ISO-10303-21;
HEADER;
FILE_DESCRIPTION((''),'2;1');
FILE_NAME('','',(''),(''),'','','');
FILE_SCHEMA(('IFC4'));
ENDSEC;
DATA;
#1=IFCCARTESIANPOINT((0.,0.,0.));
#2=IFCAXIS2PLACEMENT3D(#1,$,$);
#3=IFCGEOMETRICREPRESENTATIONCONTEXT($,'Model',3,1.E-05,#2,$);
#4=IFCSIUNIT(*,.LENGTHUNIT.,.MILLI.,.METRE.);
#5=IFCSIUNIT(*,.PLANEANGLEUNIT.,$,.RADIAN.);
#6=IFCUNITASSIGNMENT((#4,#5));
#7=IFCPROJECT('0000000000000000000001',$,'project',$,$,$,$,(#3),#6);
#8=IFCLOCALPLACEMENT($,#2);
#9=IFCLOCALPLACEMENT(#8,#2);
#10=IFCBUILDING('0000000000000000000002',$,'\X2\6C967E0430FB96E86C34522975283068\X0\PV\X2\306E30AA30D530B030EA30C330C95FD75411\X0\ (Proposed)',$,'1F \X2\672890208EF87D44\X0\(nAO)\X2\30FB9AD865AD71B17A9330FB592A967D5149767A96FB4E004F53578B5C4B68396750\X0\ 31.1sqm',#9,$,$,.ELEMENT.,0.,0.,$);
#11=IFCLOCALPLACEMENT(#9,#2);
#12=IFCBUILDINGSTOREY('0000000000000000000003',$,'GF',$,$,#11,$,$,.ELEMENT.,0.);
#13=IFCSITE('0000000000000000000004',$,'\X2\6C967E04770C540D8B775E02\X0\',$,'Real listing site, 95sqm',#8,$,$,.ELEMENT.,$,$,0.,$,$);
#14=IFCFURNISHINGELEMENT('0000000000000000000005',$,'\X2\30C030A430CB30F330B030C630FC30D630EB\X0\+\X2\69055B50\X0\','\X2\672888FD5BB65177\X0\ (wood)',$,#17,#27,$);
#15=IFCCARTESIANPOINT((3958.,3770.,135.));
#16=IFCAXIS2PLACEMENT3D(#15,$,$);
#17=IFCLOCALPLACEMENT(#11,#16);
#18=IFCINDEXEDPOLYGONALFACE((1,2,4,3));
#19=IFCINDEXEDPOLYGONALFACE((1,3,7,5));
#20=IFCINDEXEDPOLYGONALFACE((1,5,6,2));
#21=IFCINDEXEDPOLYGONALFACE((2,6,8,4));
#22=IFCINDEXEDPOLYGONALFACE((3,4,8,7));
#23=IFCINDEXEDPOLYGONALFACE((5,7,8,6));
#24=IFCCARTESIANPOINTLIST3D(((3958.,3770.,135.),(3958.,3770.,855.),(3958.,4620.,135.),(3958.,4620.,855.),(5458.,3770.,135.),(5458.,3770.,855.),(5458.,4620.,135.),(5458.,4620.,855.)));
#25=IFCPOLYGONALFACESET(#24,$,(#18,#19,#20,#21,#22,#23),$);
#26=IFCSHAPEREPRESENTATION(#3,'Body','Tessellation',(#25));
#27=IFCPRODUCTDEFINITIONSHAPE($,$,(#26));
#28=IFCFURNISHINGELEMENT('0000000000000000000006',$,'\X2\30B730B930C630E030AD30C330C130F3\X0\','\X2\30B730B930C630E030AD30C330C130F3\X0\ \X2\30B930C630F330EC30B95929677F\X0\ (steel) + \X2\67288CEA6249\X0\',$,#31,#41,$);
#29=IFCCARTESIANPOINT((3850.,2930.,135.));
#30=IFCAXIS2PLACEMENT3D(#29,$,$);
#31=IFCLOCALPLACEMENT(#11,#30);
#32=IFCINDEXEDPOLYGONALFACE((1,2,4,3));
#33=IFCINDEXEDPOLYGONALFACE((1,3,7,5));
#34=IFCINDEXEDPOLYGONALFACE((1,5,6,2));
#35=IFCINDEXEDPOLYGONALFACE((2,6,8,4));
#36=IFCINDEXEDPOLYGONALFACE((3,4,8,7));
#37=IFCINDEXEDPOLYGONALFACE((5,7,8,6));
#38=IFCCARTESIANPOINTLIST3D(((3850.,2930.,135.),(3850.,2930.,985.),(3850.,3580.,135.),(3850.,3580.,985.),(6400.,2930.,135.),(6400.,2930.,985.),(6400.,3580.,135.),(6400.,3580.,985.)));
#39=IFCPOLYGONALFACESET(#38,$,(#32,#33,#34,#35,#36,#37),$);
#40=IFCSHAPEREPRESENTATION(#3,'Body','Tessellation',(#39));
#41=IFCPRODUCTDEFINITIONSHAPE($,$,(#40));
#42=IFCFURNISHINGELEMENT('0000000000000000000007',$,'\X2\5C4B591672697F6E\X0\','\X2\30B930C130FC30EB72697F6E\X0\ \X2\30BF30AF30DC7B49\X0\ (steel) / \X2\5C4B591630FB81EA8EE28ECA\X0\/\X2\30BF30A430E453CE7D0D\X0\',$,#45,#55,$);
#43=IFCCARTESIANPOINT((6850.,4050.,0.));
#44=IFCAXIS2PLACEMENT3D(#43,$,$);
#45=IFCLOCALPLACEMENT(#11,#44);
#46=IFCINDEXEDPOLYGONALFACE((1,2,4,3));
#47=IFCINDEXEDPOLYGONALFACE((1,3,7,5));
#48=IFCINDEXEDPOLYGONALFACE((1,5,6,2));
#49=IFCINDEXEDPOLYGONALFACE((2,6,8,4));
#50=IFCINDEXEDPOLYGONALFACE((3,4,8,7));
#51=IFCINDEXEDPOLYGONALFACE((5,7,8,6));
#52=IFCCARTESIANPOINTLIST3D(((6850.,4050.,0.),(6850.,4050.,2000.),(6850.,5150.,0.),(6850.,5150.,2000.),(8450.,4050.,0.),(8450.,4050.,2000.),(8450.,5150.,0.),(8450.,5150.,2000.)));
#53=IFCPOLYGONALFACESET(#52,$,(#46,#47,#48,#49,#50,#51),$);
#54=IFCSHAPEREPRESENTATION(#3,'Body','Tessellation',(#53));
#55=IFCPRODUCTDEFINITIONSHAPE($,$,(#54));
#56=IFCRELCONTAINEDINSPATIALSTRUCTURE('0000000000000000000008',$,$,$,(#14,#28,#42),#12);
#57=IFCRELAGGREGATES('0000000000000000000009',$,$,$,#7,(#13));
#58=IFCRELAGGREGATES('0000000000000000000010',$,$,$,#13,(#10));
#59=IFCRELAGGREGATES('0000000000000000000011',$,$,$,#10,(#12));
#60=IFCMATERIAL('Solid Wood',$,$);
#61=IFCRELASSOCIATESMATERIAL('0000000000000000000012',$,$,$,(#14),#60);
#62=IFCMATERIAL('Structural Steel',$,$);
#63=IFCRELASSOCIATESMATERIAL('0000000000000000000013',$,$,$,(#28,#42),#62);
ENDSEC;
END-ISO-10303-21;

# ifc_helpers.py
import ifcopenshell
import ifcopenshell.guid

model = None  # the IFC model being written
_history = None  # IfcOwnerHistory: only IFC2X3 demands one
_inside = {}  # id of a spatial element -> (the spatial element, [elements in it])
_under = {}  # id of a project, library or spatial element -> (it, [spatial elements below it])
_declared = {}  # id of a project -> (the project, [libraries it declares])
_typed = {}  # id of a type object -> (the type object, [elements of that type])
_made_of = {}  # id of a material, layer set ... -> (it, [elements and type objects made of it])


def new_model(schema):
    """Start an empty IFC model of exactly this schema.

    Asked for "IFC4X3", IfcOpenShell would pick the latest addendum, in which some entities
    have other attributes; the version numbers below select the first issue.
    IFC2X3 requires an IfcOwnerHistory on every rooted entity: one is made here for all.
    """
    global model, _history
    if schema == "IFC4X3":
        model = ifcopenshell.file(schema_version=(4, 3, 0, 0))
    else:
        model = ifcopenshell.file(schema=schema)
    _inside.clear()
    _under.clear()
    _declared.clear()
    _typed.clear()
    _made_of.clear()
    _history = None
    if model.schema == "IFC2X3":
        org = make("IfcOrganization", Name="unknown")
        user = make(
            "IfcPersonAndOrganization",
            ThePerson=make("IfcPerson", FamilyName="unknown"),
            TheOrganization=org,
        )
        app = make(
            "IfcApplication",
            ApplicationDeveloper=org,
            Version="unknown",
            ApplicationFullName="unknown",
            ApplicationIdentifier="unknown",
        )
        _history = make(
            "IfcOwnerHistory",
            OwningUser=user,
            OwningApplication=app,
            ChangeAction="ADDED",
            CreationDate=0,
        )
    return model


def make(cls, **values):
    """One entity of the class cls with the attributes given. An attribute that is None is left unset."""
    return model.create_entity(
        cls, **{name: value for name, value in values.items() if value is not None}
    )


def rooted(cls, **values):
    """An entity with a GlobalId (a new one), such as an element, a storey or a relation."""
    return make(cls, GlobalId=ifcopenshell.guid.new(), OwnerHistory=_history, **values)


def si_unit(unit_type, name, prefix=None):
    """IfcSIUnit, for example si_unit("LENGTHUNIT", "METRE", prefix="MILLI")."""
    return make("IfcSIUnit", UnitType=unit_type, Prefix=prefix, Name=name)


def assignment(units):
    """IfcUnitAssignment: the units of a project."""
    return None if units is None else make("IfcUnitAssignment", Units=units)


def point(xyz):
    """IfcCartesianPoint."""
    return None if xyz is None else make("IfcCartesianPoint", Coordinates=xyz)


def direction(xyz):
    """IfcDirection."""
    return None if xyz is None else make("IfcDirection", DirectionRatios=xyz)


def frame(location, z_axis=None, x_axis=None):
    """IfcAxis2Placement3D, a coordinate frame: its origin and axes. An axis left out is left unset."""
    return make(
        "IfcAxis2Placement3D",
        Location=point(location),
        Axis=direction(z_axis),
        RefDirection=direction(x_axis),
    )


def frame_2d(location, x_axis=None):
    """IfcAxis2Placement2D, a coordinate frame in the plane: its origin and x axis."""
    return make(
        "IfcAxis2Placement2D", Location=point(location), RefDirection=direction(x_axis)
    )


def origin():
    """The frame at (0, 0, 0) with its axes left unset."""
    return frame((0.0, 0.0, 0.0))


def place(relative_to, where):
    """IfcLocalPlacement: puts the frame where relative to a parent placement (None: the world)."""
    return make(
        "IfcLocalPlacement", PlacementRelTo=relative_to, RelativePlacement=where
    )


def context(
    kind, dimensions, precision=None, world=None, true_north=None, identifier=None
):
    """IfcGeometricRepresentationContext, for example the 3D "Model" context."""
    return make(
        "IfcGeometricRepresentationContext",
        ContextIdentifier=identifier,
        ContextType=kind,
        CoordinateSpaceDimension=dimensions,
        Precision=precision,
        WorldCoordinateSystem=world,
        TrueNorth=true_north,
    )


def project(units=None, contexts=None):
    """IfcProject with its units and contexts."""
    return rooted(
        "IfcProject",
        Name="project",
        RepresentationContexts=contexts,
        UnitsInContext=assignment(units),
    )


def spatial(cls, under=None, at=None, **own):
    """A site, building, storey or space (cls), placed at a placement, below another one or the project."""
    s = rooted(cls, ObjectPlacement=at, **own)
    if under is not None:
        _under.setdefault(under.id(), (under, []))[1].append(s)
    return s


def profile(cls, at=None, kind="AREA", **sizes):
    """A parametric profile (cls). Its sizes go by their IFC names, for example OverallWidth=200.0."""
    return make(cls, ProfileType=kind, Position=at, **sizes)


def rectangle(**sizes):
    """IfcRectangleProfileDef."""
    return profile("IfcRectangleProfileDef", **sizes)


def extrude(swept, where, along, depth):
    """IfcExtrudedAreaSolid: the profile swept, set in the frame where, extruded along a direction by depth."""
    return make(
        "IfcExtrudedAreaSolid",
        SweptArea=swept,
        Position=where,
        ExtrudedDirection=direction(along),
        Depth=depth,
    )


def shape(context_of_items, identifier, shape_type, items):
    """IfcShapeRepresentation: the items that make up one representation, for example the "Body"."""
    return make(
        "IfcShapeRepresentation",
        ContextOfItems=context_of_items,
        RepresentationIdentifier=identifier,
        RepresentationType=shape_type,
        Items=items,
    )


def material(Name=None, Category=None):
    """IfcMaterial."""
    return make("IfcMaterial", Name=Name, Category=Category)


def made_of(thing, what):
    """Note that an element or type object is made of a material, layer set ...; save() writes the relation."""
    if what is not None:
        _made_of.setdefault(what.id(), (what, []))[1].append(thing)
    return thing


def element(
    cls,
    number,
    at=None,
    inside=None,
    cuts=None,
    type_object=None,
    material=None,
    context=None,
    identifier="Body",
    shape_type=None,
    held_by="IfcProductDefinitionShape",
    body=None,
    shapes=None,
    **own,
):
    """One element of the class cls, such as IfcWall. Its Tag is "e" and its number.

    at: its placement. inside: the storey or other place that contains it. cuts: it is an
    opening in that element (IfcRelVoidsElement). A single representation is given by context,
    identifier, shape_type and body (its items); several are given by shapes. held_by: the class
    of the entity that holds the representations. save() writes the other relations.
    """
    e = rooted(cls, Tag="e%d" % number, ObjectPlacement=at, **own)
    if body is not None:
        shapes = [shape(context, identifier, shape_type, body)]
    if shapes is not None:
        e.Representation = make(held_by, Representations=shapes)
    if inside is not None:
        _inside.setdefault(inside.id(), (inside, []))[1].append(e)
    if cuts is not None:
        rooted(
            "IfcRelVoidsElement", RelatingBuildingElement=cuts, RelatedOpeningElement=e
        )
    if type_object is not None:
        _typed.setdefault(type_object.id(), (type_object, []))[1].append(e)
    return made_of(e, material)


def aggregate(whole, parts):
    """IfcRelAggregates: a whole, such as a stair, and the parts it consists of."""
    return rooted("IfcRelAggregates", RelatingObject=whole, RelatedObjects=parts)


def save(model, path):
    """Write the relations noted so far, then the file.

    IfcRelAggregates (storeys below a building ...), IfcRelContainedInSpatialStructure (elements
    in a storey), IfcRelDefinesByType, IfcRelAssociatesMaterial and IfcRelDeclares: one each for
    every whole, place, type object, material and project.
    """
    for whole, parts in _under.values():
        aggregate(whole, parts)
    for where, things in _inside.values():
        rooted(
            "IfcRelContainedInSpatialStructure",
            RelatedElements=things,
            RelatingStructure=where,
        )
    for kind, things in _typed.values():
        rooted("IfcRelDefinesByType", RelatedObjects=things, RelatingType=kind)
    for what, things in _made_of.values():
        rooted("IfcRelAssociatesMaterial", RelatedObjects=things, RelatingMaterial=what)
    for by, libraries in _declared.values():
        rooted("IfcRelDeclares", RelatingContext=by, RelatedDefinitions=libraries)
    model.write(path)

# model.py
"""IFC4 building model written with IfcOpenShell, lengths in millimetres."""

from ifc_helpers import new_model, si_unit, frame, frame_2d, origin, place, context, project, spatial, rectangle, extrude, material, element, save


model = new_model("IFC4")

# Units and contexts
model_context = context("Model", 3, precision=1e-05, world=origin())
ifc_project = project(units=[si_unit("LENGTHUNIT", "METRE", prefix="MILLI"), si_unit("PLANEANGLEUNIT", "RADIAN")], contexts=[model_context])

# Site, building, storey
site_placement = place(None, origin())
site = spatial("IfcSite", under=ifc_project, at=site_placement, Name="沖縄県名護市", ObjectType="Real listing site, 95sqm", CompositionType="ELEMENT", RefElevation=0.0)
building_placement = place(site_placement, origin())
building = spatial("IfcBuilding", under=site, at=building_placement, Name="沖縄・雨水利用とPVのオフグリッド志向 (Proposed)", ObjectType="1F 木造軸組(nAO)・高断熱窓・太陽光発電一体型屋根材 31.1sqm", CompositionType="ELEMENT", ElevationOfRefHeight=0.0, ElevationOfTerrain=0.0)
storey_placement = place(building_placement, origin())
storey = spatial("IfcBuildingStorey", under=building, at=storey_placement, Name="GF", CompositionType="ELEMENT", Elevation=0.0)

# Shared definitions
ifc_material_1 = material(Name="Solid Wood")

# Shared definitions
ifc_material_2 = material(Name="Structural Steel")

# Furnishing elements
furnishing_1_placement = place(storey_placement, frame((3958.0, 3770.0, 135.0)))
element("IfcFurnishingElement", 1, at=furnishing_1_placement, inside=storey, material=ifc_material_1, Name="ダイニングテーブル+椅子", Description="木製家具 (wood)", context=model_context, shape_type="SweptSolid", body=[
    extrude(rectangle(XDim=1500.0, YDim=850.0, at=frame_2d((750.0, 425.0))), frame((3958.0, 3770.0, 135.0)), (0.0, 0.0, 1.0), 720.0),
])
furnishing_2_placement = place(storey_placement, frame((3850.0, 2930.0, 135.0)))
element("IfcFurnishingElement", 2, at=furnishing_2_placement, inside=storey, material=ifc_material_2, Name="システムキッチン", Description="システムキッチン ステンレス天板 (steel) + 木質扉", context=model_context, shape_type="SweptSolid", body=[
    extrude(rectangle(XDim=2550.0, YDim=650.0, at=frame_2d((1275.0, 325.0))), frame((3850.0, 2930.0, 135.0)), (0.0, 0.0, 1.0), 850.0),
])
furnishing_3_placement = place(storey_placement, frame((6850.0, 4050.0, 0.0)))
element("IfcFurnishingElement", 3, at=furnishing_3_placement, inside=storey, material=ifc_material_2, Name="屋外物置", Description="スチール物置 タクボ等 (steel) / 屋外・自転車/タイヤ収納", context=model_context, shape_type="SweptSolid", body=[
    extrude(rectangle(XDim=1600.0, YDim=1100.0, at=frame_2d((800.0, 550.0))), frame((6850.0, 4050.0, 0.0)), (0.0, 0.0, 1.0), 2000.0),
])

save(model, "model.ifc")
